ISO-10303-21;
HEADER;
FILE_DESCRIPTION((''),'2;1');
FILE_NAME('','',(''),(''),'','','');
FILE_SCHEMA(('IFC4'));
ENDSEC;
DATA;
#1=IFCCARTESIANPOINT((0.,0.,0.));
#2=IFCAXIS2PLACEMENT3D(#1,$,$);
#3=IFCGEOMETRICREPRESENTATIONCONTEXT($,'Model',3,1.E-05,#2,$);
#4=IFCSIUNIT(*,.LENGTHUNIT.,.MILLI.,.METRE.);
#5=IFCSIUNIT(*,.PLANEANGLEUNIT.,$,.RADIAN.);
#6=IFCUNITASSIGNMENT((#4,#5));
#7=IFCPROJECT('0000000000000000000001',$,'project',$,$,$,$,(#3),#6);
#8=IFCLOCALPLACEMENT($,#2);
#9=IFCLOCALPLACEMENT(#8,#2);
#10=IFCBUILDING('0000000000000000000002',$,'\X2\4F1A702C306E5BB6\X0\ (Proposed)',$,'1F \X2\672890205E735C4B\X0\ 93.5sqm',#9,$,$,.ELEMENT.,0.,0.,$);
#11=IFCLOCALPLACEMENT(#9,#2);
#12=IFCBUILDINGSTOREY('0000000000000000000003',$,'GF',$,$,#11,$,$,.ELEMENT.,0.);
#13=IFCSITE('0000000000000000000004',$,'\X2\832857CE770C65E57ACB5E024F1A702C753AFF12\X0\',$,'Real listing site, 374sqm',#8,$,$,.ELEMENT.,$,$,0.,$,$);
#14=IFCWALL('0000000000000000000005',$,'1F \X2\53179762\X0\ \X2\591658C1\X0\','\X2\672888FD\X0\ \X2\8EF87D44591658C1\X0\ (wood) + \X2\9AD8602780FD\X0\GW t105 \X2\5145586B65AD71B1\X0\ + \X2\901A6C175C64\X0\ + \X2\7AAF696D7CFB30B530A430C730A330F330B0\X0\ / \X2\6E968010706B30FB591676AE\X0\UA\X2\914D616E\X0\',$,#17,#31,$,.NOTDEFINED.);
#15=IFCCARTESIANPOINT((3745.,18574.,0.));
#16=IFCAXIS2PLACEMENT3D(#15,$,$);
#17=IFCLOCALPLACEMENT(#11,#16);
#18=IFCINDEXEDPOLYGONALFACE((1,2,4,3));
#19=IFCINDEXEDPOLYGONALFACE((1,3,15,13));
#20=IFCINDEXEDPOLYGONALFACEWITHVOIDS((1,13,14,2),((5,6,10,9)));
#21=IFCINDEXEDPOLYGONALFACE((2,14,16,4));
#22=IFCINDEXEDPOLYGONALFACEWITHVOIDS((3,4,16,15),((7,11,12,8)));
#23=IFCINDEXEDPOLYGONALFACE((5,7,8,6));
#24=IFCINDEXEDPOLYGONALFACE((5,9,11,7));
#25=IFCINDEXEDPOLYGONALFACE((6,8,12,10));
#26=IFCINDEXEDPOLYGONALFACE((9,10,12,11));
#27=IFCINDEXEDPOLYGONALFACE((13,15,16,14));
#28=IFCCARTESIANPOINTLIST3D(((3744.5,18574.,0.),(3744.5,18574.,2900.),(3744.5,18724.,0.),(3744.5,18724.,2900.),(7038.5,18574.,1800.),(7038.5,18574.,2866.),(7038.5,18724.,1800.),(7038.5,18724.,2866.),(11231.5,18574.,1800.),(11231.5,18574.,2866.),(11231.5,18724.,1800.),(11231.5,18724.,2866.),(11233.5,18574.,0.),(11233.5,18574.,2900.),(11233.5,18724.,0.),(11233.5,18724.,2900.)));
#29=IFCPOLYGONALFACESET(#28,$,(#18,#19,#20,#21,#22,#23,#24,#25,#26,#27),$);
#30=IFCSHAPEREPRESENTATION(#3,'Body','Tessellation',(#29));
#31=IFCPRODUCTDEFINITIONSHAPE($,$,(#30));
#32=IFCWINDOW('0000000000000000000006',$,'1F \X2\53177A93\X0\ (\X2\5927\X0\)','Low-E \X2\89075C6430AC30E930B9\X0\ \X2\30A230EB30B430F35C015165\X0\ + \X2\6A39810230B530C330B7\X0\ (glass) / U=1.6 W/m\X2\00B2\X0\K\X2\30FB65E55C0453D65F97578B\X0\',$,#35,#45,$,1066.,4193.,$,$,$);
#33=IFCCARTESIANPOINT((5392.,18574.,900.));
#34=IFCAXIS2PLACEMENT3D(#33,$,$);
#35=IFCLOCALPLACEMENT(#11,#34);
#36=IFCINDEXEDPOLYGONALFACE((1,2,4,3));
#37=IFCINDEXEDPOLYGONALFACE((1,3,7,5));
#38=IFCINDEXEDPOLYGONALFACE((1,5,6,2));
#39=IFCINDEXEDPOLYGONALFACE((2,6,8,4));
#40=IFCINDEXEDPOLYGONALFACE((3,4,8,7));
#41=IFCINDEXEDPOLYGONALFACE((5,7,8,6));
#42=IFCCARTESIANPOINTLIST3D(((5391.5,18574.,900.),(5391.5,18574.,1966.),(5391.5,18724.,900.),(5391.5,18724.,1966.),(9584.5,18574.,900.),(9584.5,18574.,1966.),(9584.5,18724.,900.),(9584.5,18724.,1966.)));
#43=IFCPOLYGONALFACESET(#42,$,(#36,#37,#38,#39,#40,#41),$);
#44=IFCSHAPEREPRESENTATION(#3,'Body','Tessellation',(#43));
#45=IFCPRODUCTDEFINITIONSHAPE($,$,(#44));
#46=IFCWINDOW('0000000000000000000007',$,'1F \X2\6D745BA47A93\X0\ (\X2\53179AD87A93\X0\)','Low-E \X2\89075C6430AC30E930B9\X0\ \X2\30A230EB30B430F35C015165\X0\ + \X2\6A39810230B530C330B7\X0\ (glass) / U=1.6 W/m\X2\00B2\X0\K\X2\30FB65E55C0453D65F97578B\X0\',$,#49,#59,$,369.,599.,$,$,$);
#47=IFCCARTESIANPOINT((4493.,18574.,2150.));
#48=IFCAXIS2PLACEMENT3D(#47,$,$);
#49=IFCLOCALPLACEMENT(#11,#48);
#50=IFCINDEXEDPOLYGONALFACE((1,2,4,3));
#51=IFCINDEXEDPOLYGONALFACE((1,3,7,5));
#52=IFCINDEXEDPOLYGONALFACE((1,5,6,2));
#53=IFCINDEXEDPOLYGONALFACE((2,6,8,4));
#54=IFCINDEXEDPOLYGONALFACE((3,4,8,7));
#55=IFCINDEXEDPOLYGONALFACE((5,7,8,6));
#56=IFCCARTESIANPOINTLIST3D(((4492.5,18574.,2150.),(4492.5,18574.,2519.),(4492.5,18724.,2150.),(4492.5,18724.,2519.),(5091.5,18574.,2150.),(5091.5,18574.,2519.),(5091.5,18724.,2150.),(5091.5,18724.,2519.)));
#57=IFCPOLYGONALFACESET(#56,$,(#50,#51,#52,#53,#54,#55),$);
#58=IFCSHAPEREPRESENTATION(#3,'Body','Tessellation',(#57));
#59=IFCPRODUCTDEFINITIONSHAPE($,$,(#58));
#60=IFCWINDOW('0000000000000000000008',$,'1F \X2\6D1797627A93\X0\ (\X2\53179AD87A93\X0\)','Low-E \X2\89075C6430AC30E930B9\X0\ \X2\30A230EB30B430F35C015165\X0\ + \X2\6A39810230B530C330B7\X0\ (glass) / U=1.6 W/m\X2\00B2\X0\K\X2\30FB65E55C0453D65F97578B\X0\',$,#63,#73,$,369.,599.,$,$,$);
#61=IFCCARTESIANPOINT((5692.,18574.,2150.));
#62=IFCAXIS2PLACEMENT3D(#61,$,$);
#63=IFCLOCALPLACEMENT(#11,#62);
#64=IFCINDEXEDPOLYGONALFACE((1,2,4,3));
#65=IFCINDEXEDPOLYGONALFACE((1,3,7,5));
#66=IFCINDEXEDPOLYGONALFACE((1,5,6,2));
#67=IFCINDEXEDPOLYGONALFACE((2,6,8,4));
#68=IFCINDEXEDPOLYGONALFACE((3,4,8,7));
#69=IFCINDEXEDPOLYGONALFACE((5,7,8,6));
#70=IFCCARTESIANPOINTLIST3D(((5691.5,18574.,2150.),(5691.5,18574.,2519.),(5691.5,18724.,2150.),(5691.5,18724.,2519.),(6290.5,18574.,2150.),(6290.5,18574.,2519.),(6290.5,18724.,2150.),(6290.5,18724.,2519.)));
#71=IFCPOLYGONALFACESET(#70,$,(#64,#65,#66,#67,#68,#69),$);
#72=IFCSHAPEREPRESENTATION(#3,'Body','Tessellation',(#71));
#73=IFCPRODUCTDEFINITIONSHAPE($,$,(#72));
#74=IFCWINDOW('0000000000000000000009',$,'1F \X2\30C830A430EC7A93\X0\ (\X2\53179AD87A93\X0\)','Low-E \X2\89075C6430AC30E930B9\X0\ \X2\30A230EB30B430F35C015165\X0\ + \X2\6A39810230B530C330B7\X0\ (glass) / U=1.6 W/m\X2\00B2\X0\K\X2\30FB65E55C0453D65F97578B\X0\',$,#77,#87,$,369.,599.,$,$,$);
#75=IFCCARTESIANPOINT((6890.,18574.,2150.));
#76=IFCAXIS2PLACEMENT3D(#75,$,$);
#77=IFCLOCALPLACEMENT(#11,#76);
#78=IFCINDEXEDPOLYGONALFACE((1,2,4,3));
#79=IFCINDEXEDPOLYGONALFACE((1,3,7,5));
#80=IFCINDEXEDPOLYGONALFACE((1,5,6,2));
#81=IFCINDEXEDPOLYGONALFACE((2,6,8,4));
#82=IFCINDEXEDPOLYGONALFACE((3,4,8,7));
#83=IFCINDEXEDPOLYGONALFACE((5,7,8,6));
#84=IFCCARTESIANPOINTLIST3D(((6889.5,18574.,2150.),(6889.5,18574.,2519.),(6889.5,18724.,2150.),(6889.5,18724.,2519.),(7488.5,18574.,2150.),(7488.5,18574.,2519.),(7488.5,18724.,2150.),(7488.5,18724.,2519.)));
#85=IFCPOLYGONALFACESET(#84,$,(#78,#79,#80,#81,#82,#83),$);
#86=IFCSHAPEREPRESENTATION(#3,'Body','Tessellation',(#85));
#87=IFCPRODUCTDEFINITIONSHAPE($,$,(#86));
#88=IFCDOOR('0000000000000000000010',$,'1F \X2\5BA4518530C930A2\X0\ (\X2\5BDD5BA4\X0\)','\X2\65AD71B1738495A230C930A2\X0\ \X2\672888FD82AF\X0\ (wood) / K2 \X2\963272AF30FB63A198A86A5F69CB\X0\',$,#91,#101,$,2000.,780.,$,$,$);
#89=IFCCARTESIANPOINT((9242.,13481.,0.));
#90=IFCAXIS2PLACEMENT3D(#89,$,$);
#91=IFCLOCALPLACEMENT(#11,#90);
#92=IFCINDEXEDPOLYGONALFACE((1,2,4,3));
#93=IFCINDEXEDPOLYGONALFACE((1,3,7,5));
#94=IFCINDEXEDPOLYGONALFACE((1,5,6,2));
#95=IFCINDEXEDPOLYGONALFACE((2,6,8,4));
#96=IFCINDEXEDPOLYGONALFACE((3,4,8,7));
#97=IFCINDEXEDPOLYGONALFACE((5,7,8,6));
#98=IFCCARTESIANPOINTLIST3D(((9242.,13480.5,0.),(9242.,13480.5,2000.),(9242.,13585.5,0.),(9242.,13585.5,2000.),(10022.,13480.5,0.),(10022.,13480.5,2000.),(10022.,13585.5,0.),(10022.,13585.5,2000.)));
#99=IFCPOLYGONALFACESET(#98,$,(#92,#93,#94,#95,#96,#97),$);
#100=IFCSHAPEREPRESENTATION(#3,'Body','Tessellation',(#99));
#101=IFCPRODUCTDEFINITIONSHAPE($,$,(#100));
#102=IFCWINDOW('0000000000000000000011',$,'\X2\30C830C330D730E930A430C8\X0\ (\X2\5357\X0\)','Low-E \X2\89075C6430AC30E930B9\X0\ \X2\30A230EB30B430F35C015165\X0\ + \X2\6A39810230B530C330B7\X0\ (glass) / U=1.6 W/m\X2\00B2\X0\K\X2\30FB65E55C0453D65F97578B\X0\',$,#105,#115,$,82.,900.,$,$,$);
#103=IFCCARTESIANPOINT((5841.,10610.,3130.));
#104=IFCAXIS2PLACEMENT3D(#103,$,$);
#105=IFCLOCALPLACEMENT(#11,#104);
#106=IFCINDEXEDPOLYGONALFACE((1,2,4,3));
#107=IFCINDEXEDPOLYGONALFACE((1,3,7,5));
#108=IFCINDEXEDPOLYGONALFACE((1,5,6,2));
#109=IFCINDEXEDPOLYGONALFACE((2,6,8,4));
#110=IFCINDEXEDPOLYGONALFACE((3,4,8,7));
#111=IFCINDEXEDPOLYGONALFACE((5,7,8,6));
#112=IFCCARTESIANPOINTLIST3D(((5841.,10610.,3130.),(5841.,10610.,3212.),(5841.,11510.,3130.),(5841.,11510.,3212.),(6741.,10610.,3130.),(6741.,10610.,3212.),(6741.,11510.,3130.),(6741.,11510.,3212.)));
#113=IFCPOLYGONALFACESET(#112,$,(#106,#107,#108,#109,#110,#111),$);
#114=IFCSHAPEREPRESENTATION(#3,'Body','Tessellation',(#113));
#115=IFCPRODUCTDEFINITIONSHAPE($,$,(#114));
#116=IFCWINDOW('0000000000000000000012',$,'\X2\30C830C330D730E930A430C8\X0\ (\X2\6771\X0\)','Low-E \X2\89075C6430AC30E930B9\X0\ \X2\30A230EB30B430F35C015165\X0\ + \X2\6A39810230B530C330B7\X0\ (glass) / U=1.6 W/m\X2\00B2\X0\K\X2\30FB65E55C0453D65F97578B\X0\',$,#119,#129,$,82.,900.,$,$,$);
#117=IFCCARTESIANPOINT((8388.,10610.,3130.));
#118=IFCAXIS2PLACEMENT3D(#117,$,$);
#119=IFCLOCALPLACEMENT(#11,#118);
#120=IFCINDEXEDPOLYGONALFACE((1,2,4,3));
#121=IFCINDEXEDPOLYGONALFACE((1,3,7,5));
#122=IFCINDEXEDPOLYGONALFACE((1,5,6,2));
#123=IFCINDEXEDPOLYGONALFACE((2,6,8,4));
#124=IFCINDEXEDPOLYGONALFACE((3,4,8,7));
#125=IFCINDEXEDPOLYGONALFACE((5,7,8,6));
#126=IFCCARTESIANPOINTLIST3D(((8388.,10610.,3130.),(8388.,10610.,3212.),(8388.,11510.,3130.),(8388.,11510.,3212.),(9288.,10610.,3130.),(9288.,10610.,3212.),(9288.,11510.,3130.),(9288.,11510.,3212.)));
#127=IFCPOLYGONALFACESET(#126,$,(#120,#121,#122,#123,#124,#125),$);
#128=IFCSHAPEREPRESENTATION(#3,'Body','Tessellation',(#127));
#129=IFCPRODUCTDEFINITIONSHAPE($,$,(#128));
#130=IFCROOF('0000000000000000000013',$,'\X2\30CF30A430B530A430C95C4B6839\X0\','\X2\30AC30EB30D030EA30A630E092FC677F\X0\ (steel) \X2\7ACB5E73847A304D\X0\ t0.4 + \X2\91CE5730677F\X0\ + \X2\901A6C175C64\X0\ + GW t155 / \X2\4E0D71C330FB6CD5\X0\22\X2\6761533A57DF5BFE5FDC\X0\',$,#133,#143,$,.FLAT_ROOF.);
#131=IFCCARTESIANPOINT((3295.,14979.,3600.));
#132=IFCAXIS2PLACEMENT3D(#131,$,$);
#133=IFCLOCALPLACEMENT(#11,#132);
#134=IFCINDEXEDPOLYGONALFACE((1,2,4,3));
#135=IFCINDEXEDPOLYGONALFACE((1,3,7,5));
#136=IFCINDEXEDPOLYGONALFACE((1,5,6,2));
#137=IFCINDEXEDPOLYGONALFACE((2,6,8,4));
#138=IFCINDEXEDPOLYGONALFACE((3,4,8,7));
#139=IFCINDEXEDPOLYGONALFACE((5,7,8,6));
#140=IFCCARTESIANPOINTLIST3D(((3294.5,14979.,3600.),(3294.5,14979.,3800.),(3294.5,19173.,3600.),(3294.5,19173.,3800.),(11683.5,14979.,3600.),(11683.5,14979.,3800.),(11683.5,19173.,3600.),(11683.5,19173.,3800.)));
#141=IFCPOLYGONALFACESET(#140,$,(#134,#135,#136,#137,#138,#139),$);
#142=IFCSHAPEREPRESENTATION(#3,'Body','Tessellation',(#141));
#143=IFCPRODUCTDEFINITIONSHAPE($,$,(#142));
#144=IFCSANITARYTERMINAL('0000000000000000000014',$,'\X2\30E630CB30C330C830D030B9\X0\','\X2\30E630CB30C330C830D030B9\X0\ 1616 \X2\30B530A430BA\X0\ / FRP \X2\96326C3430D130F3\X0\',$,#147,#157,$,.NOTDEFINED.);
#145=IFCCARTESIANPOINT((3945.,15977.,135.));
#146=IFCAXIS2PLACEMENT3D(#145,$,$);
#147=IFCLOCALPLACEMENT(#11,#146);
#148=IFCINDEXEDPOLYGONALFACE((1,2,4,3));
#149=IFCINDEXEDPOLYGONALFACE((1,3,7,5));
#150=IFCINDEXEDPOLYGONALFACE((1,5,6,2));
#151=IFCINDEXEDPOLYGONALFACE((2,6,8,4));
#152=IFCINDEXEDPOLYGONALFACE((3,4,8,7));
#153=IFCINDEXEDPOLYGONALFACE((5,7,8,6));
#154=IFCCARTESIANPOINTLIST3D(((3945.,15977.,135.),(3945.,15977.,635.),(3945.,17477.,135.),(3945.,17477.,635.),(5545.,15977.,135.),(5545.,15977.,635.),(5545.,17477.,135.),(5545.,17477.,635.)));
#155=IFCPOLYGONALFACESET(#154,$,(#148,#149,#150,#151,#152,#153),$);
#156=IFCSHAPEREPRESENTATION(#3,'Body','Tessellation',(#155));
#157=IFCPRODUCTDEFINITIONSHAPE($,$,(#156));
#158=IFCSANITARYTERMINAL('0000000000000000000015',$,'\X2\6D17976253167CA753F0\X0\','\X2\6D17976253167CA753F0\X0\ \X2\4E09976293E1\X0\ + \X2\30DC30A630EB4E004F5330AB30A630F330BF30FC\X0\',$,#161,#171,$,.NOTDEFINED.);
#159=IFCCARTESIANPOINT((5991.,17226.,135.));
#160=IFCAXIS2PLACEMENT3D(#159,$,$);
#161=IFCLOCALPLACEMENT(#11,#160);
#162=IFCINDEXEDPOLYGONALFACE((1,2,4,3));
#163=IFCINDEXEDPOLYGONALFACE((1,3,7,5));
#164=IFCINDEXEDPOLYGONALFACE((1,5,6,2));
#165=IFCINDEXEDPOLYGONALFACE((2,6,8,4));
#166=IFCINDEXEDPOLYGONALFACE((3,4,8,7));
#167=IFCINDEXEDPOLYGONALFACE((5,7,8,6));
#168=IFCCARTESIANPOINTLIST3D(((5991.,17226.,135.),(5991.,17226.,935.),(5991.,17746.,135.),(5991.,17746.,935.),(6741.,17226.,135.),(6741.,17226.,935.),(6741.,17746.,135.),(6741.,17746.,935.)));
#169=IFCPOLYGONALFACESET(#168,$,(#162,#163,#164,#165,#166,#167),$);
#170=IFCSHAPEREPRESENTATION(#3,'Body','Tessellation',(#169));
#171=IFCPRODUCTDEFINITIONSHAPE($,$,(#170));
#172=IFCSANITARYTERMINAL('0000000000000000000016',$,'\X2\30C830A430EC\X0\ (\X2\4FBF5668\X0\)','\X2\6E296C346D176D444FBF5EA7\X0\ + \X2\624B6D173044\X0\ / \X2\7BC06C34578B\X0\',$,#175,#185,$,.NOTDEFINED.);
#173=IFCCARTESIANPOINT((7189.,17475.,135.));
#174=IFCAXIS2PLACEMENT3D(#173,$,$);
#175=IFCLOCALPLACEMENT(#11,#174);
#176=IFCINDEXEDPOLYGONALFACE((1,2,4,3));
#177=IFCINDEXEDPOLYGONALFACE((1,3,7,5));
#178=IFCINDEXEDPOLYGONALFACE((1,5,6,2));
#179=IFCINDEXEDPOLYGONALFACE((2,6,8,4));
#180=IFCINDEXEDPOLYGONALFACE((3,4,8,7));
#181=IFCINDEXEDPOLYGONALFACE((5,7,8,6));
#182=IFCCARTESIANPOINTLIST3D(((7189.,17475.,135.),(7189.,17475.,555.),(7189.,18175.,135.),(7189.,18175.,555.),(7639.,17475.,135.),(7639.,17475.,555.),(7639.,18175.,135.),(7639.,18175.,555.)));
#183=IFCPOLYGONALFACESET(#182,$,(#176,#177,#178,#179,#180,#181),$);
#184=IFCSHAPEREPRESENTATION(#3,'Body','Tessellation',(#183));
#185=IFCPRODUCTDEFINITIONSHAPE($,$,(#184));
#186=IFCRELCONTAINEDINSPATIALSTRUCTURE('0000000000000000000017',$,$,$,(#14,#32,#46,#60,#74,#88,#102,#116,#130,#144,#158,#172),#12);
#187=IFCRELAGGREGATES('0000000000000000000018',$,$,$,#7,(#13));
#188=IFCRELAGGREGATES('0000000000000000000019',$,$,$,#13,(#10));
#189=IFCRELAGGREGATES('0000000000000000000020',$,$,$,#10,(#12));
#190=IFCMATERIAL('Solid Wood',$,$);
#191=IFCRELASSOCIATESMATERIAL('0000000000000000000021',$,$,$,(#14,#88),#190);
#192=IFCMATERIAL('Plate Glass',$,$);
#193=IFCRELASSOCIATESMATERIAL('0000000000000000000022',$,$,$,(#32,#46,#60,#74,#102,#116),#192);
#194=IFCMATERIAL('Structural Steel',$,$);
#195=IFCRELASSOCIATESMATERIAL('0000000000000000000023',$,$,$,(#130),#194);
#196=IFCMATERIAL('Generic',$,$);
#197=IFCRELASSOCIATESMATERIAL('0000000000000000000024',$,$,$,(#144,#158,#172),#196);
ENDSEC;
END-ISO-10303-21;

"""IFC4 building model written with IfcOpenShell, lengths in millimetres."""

from ifc_helpers import new_model, si_unit, frame, frame_2d, origin, place, context, project, spatial, rectangle, extrude, material, element, fill, save


model = new_model("IFC4")

# Units and contexts
model_context = context("Model", 3, precision=1e-05, world=origin())
ifc_project = project(units=[si_unit("LENGTHUNIT", "METRE", prefix="MILLI"), si_unit("PLANEANGLEUNIT", "RADIAN")], contexts=[model_context])

# Site, building, storey
site_placement = place(None, origin())
site = spatial("IfcSite", under=ifc_project, at=site_placement, Name="茨城県日立市会瀬町２", ObjectType="Real listing site, 374sqm", CompositionType="ELEMENT", RefElevation=0.0)
building_placement = place(site_placement, origin())
building = spatial("IfcBuilding", under=site, at=building_placement, Name="会瀬の家 (Proposed)", ObjectType="1F 木造平屋 93.5sqm", CompositionType="ELEMENT", ElevationOfRefHeight=0.0, ElevationOfTerrain=0.0)
storey_placement = place(building_placement, origin())
storey = spatial("IfcBuildingStorey", under=building, at=storey_placement, Name="GF", CompositionType="ELEMENT", Elevation=0.0)

# Shared definitions
ifc_material_1 = material(Name="Solid Wood")

# Wall, openings, windows
wall_1_placement = place(storey_placement, frame((3745.0, 18574.0, 0.0)))
wall_1 = element("IfcWall", 1, at=wall_1_placement, inside=storey, material=ifc_material_1, Name="1F 北面 外壁", Description="木製 軸組外壁 (wood) + 高性能GW t105 充填断熱 + 通気層 + 窯業系サイディング / 準耐火・外皮UA配慮", PredefinedType="NOTDEFINED", context=model_context, shape_type="SweptSolid", body=[
    extrude(rectangle(XDim=7489.0, YDim=150.0, at=frame_2d((3744.0, 75.0))), frame((3745.0, 18574.0, 0.0)), (0.0, 0.0, 1.0), 2900.0),
])
opening_1_placement = place(storey_placement, frame((5392.0, 18574.0, 900.0)))
opening_1 = element("IfcOpeningElement", 2, at=opening_1_placement, cuts=wall_1, PredefinedType="NOTDEFINED", context=model_context, shape_type="SweptSolid", body=[
    extrude(rectangle(XDim=4193.0, YDim=150.0, at=frame_2d((2096.0, 75.0))), frame((5392.0, 18574.0, 900.0)), (0.0, 0.0, 1.0), 1066.0),
])
opening_2_placement = place(storey_placement, frame((4493.0, 18574.0, 2150.0)))
opening_2 = element("IfcOpeningElement", 3, at=opening_2_placement, cuts=wall_1, PredefinedType="NOTDEFINED", context=model_context, shape_type="SweptSolid", body=[
    extrude(rectangle(XDim=599.0, YDim=150.0, at=frame_2d((299.0, 75.0))), frame((4493.0, 18574.0, 2150.0)), (0.0, 0.0, 1.0), 369.0),
])
opening_3_placement = place(storey_placement, frame((5692.0, 18574.0, 2150.0)))
opening_3 = element("IfcOpeningElement", 4, at=opening_3_placement, cuts=wall_1, PredefinedType="NOTDEFINED", context=model_context, shape_type="SweptSolid", body=[
    extrude(rectangle(XDim=599.0, YDim=150.0, at=frame_2d((299.0, 75.0))), frame((5692.0, 18574.0, 2150.0)), (0.0, 0.0, 1.0), 369.0),
])
opening_4_placement = place(storey_placement, frame((6890.0, 18574.0, 2150.0)))
opening_4 = element("IfcOpeningElement", 5, at=opening_4_placement, cuts=wall_1, PredefinedType="NOTDEFINED", context=model_context, shape_type="SweptSolid", body=[
    extrude(rectangle(XDim=599.0, YDim=150.0, at=frame_2d((299.0, 75.0))), frame((6890.0, 18574.0, 2150.0)), (0.0, 0.0, 1.0), 369.0),
])
ifc_material_2 = material(Name="Plate Glass")
window_1_placement = place(storey_placement, frame((5392.0, 18574.0, 900.0)))
window_1 = element("IfcWindow", 6, at=window_1_placement, inside=storey, material=ifc_material_2, Name="1F 北窓 (大)", Description="Low-E 複層ガラス アルゴン封入 + 樹脂サッシ (glass) / U=1.6 W/m²K・日射取得型", OverallHeight=1066.0, OverallWidth=4193.0, context=model_context, shape_type="SweptSolid", body=[
    extrude(rectangle(XDim=4193.0, YDim=150.0, at=frame_2d((2096.0, 75.0))), frame((5392.0, 18574.0, 900.0)), (0.0, 0.0, 1.0), 1066.0),
])
fill(opening_1, window_1)
window_2_placement = place(storey_placement, frame((4493.0, 18574.0, 2150.0)))
window_2 = element("IfcWindow", 7, at=window_2_placement, inside=storey, material=ifc_material_2, Name="1F 浴室窓 (北高窓)", Description="Low-E 複層ガラス アルゴン封入 + 樹脂サッシ (glass) / U=1.6 W/m²K・日射取得型", OverallHeight=369.0, OverallWidth=599.0, context=model_context, shape_type="SweptSolid", body=[
    extrude(rectangle(XDim=599.0, YDim=150.0, at=frame_2d((299.0, 75.0))), frame((4493.0, 18574.0, 2150.0)), (0.0, 0.0, 1.0), 369.0),
])
fill(opening_2, window_2)
window_3_placement = place(storey_placement, frame((5692.0, 18574.0, 2150.0)))
window_3 = element("IfcWindow", 8, at=window_3_placement, inside=storey, material=ifc_material_2, Name="1F 洗面窓 (北高窓)", Description="Low-E 複層ガラス アルゴン封入 + 樹脂サッシ (glass) / U=1.6 W/m²K・日射取得型", OverallHeight=369.0, OverallWidth=599.0, context=model_context, shape_type="SweptSolid", body=[
    extrude(rectangle(XDim=599.0, YDim=150.0, at=frame_2d((299.0, 75.0))), frame((5692.0, 18574.0, 2150.0)), (0.0, 0.0, 1.0), 369.0),
])
fill(opening_3, window_3)
window_4_placement = place(storey_placement, frame((6890.0, 18574.0, 2150.0)))
window_4 = element("IfcWindow", 9, at=window_4_placement, inside=storey, material=ifc_material_2, Name="1F トイレ窓 (北高窓)", Description="Low-E 複層ガラス アルゴン封入 + 樹脂サッシ (glass) / U=1.6 W/m²K・日射取得型", OverallHeight=369.0, OverallWidth=599.0, context=model_context, shape_type="SweptSolid", body=[
    extrude(rectangle(XDim=599.0, YDim=150.0, at=frame_2d((299.0, 75.0))), frame((6890.0, 18574.0, 2150.0)), (0.0, 0.0, 1.0), 369.0),
])
fill(opening_4, window_4)

# Door
door_1_placement = place(storey_placement, frame((9242.0, 13481.0, 0.0)))
element("IfcDoor", 10, at=door_1_placement, inside=storey, material=ifc_material_1, Name="1F 室内ドア (寝室)", Description="断熱玄関ドア 木製芯 (wood) / K2 防犯・採風機構", OverallHeight=2000.0, OverallWidth=780.0, context=model_context, shape_type="SweptSolid", body=[
    extrude(rectangle(XDim=780.0, YDim=105.0, at=frame_2d((390.0, 52.0))), frame((9242.0, 13481.0, 0.0)), (0.0, 0.0, 1.0), 2000.0),
])

# Windows
window_5_placement = place(storey_placement, frame((5841.0, 10610.0, 3130.0)))
element("IfcWindow", 11, at=window_5_placement, inside=storey, material=ifc_material_2, Name="トップライト (南)", Description="Low-E 複層ガラス アルゴン封入 + 樹脂サッシ (glass) / U=1.6 W/m²K・日射取得型", OverallHeight=82.0, OverallWidth=900.0, context=model_context, shape_type="SweptSolid", body=[
    extrude(rectangle(XDim=900.0, YDim=900.0, at=frame_2d((450.0, 450.0))), frame((5841.0, 10610.0, 3130.0)), (0.0, 0.0, 1.0), 82.0),
])
window_6_placement = place(storey_placement, frame((8388.0, 10610.0, 3130.0)))
element("IfcWindow", 12, at=window_6_placement, inside=storey, material=ifc_material_2, Name="トップライト (東)", Description="Low-E 複層ガラス アルゴン封入 + 樹脂サッシ (glass) / U=1.6 W/m²K・日射取得型", OverallHeight=82.0, OverallWidth=900.0, context=model_context, shape_type="SweptSolid", body=[
    extrude(rectangle(XDim=900.0, YDim=900.0, at=frame_2d((450.0, 450.0))), frame((8388.0, 10610.0, 3130.0)), (0.0, 0.0, 1.0), 82.0),
])

# Roof
ifc_material_3 = material(Name="Structural Steel")
roof_placement = place(storey_placement, frame((3295.0, 14979.0, 3600.0)))
element("IfcRoof", 13, at=roof_placement, inside=storey, material=ifc_material_3, Name="ハイサイド屋根", Description="ガルバリウム鋼板 (steel) 立平葺き t0.4 + 野地板 + 通気層 + GW t155 / 不燃・法22条区域対応", PredefinedType="FLAT_ROOF", context=model_context, shape_type="SweptSolid", body=[
    extrude(rectangle(XDim=8389.0, YDim=4194.0, at=frame_2d((4194.0, 2097.0))), frame((3295.0, 14979.0, 3600.0)), (0.0, 0.0, 1.0), 200.0),
])

# Sanitary terminals
ifc_material_4 = material(Name="Generic")
sanitary_terminal_1_placement = place(storey_placement, frame((3945.0, 15977.0, 135.0)))
element("IfcSanitaryTerminal", 14, at=sanitary_terminal_1_placement, inside=storey, material=ifc_material_4, Name="ユニットバス", Description="ユニットバス 1616 サイズ / FRP 防水パン", PredefinedType="NOTDEFINED", context=model_context, shape_type="SweptSolid", body=[
    extrude(rectangle(XDim=1600.0, YDim=1500.0, at=frame_2d((800.0, 750.0))), frame((3945.0, 15977.0, 135.0)), (0.0, 0.0, 1.0), 500.0),
])
sanitary_terminal_2_placement = place(storey_placement, frame((5991.0, 17226.0, 135.0)))
element("IfcSanitaryTerminal", 15, at=sanitary_terminal_2_placement, inside=storey, material=ifc_material_4, Name="洗面化粧台", Description="洗面化粧台 三面鏡 + ボウル一体カウンター", PredefinedType="NOTDEFINED", context=model_context, shape_type="SweptSolid", body=[
    extrude(rectangle(XDim=750.0, YDim=520.0, at=frame_2d((375.0, 260.0))), frame((5991.0, 17226.0, 135.0)), (0.0, 0.0, 1.0), 800.0),
])
sanitary_terminal_3_placement = place(storey_placement, frame((7189.0, 17475.0, 135.0)))
element("IfcSanitaryTerminal", 16, at=sanitary_terminal_3_placement, inside=storey, material=ifc_material_4, Name="トイレ (便器)", Description="温水洗浄便座 + 手洗い / 節水型", PredefinedType="NOTDEFINED", context=model_context, shape_type="SweptSolid", body=[
    extrude(rectangle(XDim=450.0, YDim=700.0, at=frame_2d((225.0, 350.0))), frame((7189.0, 17475.0, 135.0)), (0.0, 0.0, 1.0), 420.0),
])

save(model, "model.ifc")
